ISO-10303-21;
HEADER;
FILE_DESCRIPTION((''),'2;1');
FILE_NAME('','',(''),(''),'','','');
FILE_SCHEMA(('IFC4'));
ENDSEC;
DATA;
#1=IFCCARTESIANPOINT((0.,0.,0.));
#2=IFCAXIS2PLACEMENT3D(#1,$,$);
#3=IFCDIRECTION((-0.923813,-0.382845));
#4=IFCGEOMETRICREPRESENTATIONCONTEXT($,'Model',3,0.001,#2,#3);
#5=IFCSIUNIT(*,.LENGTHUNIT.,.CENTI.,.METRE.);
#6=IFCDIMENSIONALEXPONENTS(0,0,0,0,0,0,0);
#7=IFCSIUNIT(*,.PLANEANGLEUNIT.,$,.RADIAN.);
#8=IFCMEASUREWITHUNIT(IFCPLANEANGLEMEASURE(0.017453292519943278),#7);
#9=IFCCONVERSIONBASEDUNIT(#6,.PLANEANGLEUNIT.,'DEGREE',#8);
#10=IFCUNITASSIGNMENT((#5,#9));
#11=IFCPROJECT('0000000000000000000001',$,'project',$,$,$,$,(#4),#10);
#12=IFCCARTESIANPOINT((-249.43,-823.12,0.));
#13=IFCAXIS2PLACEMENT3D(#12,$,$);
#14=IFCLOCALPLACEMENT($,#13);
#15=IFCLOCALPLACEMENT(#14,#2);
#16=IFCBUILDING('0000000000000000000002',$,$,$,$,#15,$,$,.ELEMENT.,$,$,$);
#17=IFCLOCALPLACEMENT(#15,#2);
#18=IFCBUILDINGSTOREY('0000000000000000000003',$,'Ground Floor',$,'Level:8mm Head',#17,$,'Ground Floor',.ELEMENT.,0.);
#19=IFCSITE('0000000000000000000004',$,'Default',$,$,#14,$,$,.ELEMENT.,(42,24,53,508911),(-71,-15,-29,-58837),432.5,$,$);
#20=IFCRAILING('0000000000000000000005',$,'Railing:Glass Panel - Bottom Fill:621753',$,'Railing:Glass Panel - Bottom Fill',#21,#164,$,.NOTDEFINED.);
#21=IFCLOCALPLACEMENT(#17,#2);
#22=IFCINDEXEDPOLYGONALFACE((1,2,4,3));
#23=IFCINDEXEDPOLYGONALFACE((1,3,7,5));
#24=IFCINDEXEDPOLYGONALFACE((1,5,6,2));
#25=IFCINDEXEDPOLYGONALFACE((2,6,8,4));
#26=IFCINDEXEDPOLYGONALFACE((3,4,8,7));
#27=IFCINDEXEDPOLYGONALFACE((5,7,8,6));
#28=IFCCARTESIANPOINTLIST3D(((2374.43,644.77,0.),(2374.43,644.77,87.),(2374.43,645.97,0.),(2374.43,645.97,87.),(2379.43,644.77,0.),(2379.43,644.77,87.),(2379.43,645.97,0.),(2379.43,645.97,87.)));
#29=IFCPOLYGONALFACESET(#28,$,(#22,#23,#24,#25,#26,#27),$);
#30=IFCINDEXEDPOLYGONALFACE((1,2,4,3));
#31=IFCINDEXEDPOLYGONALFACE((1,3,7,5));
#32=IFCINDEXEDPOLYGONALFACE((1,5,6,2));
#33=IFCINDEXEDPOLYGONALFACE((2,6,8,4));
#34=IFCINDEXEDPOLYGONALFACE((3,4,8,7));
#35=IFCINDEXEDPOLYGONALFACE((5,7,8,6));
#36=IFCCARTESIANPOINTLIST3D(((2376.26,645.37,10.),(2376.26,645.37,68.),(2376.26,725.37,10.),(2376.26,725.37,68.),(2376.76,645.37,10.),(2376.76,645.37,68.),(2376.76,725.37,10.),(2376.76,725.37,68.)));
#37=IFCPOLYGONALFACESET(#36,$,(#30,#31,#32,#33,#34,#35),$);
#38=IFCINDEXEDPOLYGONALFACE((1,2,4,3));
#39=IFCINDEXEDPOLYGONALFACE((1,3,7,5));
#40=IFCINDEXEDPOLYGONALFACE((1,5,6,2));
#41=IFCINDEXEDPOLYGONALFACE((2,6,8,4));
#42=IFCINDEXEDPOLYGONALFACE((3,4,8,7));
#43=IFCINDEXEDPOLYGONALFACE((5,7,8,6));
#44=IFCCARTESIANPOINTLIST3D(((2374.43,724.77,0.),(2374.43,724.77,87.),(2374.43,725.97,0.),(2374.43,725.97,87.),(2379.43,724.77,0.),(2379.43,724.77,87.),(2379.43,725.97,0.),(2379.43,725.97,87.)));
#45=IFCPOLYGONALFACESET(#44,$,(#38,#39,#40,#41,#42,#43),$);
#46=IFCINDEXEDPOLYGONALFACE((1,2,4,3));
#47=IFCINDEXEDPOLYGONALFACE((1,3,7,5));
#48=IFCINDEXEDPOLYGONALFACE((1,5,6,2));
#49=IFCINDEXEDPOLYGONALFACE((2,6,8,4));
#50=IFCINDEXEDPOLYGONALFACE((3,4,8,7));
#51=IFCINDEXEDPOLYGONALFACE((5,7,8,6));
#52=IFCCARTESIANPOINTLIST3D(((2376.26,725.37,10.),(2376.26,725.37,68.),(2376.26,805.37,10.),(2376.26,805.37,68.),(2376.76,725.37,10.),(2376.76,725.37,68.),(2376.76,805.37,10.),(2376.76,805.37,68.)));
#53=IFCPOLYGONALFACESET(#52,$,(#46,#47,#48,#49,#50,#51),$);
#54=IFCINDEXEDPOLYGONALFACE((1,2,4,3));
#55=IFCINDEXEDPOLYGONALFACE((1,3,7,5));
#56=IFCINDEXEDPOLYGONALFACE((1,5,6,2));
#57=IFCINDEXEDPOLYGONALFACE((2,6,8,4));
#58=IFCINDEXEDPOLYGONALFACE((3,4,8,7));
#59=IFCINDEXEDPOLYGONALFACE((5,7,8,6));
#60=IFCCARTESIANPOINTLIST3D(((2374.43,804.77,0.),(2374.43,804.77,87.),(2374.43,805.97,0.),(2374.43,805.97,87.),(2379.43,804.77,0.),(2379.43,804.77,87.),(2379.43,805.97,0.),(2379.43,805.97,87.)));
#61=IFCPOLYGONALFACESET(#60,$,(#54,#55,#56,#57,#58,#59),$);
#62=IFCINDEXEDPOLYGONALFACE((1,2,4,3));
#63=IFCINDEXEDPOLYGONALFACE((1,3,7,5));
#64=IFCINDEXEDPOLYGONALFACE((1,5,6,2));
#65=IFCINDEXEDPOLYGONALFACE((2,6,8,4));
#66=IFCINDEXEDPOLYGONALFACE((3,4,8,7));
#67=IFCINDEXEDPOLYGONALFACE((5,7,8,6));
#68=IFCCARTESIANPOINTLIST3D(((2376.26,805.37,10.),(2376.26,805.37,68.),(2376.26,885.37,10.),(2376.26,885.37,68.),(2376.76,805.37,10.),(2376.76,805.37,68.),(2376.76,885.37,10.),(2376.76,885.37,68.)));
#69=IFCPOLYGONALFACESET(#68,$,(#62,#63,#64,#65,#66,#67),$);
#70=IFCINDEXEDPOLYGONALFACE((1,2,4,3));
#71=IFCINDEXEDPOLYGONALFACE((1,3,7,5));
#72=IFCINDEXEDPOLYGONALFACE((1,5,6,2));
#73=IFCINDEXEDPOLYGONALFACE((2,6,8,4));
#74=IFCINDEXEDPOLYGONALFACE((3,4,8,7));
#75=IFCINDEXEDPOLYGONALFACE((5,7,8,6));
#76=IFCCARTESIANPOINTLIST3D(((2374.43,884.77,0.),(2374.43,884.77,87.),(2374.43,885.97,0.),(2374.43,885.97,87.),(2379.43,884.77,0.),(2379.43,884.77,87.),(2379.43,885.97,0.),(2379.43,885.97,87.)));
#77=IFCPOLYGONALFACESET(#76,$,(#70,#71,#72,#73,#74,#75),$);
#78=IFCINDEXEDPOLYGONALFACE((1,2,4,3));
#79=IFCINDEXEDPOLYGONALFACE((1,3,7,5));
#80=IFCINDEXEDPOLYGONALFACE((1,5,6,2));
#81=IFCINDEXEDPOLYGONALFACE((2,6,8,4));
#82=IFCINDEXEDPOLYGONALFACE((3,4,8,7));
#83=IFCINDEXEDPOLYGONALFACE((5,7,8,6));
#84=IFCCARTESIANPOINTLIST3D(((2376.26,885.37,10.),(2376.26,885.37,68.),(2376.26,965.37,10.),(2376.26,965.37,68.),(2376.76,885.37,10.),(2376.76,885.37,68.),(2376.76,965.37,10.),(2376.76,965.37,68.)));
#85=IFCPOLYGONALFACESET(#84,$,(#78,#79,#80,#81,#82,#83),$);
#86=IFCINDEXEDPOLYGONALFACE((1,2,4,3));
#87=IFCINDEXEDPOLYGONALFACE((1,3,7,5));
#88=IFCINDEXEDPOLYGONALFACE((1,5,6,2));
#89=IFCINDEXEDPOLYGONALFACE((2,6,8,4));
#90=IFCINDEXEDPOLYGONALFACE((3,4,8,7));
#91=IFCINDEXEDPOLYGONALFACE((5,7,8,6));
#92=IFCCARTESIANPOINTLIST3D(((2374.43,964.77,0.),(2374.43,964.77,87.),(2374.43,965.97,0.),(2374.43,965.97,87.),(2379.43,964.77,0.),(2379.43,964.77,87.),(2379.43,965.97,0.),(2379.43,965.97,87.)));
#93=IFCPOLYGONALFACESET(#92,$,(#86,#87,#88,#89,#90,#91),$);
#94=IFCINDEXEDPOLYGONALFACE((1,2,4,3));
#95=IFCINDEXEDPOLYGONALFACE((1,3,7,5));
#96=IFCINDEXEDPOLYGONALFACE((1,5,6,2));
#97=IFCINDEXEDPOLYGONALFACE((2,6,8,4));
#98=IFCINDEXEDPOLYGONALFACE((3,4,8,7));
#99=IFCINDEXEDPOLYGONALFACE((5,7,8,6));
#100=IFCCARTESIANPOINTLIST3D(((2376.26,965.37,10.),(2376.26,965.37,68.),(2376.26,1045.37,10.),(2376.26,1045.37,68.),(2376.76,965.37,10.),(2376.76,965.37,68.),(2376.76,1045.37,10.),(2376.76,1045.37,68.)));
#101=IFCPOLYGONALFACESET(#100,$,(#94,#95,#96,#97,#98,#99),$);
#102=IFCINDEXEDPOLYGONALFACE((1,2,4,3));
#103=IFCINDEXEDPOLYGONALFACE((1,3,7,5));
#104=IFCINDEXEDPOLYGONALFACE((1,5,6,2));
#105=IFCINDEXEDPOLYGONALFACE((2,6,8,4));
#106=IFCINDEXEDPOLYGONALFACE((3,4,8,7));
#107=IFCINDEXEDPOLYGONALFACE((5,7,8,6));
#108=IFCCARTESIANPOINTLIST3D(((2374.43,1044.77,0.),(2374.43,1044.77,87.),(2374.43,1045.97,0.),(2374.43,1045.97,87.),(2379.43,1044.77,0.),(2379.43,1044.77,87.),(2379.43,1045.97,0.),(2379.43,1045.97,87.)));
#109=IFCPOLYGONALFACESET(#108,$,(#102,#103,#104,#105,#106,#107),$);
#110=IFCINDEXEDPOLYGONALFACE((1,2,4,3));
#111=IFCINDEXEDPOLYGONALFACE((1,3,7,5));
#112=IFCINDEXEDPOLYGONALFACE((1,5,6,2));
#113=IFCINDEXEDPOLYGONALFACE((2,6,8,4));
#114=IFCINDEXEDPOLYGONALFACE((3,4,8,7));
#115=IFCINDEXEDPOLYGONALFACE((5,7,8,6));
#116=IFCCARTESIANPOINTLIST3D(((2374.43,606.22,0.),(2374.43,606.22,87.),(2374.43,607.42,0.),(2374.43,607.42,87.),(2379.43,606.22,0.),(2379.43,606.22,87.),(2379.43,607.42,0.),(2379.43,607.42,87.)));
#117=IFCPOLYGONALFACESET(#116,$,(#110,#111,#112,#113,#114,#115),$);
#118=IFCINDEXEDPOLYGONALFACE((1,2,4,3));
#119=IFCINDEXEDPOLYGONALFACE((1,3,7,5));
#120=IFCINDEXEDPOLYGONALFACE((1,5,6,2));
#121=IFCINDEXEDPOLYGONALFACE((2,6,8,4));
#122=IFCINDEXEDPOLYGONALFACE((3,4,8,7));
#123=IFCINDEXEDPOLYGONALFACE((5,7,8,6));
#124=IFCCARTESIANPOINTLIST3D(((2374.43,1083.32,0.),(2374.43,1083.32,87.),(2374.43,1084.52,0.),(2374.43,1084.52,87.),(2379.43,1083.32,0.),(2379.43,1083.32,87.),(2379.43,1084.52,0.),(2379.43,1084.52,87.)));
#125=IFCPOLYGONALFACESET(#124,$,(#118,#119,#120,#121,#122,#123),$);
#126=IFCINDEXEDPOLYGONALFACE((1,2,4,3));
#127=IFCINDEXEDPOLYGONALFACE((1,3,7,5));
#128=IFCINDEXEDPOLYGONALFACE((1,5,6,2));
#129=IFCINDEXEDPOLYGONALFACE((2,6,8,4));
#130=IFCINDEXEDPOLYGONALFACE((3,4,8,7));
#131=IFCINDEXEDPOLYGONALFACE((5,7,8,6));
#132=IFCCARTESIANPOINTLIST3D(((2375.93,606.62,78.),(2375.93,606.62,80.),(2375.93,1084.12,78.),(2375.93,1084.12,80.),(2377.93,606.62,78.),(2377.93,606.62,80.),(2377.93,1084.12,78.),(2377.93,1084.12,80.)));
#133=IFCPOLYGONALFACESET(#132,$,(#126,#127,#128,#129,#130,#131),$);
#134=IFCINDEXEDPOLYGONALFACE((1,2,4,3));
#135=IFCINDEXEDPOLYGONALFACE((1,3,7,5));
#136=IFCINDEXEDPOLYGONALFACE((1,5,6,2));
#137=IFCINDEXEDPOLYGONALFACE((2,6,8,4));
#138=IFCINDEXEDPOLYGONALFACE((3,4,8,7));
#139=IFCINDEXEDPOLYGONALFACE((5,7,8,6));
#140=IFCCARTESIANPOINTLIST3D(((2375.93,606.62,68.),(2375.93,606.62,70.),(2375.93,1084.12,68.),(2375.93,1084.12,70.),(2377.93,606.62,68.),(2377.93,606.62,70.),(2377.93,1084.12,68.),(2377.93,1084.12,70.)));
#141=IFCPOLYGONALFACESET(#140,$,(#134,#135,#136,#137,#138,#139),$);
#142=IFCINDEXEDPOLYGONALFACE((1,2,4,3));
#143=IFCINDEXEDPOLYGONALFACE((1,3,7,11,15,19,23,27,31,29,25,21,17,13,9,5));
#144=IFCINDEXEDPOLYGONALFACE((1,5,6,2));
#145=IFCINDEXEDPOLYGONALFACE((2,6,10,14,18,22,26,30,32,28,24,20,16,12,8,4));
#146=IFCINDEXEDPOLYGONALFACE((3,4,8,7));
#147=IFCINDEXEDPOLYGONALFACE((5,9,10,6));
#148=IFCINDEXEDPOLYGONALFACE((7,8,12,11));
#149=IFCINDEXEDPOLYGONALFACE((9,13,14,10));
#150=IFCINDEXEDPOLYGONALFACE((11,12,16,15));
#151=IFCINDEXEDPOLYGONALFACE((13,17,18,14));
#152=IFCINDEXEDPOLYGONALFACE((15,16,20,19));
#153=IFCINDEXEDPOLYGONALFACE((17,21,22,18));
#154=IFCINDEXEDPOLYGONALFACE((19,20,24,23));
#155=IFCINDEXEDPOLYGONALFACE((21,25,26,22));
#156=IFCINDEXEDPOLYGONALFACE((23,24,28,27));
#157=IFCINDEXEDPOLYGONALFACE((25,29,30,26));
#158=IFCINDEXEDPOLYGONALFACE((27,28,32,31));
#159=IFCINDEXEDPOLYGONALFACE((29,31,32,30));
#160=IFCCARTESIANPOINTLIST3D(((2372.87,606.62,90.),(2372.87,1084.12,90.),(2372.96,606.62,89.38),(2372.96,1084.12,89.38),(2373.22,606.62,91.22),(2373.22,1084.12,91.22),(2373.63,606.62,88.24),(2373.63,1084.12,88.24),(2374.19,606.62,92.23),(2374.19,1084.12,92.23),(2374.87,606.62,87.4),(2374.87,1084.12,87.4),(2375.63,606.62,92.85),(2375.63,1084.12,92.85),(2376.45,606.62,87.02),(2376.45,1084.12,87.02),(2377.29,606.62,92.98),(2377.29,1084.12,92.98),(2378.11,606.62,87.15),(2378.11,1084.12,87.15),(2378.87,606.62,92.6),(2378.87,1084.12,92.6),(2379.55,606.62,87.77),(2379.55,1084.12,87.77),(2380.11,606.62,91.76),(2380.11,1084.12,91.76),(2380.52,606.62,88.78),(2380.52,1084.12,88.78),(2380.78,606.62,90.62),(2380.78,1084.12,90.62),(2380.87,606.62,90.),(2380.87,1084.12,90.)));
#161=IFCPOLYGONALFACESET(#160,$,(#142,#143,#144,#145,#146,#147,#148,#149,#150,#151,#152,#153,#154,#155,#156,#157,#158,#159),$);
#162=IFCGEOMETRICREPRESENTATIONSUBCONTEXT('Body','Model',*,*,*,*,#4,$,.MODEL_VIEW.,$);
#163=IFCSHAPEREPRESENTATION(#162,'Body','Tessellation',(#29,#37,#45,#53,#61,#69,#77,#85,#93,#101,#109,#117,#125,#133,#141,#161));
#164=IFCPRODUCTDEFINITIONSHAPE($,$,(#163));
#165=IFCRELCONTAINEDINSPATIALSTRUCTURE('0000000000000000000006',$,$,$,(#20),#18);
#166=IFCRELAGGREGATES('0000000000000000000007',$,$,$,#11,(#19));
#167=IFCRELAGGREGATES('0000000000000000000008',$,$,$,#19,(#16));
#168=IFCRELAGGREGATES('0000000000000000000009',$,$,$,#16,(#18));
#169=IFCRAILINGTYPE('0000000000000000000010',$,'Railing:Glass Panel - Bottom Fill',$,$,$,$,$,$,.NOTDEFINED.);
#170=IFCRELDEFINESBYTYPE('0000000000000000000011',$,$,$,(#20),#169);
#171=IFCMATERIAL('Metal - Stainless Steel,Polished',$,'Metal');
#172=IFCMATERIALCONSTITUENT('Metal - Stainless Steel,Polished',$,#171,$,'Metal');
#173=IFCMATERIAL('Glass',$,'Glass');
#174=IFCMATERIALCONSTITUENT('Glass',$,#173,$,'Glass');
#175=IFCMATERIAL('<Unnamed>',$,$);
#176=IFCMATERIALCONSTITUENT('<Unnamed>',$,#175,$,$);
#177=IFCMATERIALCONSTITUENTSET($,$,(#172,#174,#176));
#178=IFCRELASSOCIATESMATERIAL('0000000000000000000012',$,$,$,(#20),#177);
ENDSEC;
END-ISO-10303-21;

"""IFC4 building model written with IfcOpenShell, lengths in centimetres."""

from ifc_helpers import new_model, entity, si_unit, converted_unit, direction, frame, origin, place, context, subcontext, project, spatial, indexed_curve, outline, extrude, material, constituent, constituent_set, type_object, element, save


model = new_model("IFC4")

# Units and contexts
model_context = context("Model", 3, precision=0.001, world=origin(), true_north=direction((-0.923813, -0.382845)))
body_context = subcontext(model_context, "Body", "Model", "MODEL_VIEW")
ifc_project = project(units=[si_unit("LENGTHUNIT", "METRE", prefix="CENTI"), converted_unit("PLANEANGLEUNIT", "DEGREE", entity("IfcPlaneAngleMeasure", 0.017453292519943278), si_unit("PLANEANGLEUNIT", "RADIAN"), dimensions=[0, 0, 0, 0, 0, 0, 0])], contexts=[model_context])

# Site, building, storey
site_placement = place(None, frame((-249.43, -823.12, 0.0)))
site = spatial("IfcSite", under=ifc_project, at=site_placement, Name="Default", CompositionType="ELEMENT", RefLatitude=(42, 24, 53, 508911), RefLongitude=(-71, -15, -29, -58837), RefElevation=432.5)
building_placement = place(site_placement, origin())
building = spatial("IfcBuilding", under=site, at=building_placement, CompositionType="ELEMENT")
storey_placement = place(building_placement, origin())
storey = spatial("IfcBuildingStorey", under=building, at=storey_placement, Name="Ground Floor", ObjectType="Level:8mm Head", LongName="Ground Floor", CompositionType="ELEMENT", Elevation=0.0)

# Shared definitions
ifc_material_1 = material(Name="Glass", Category="Glass")

# Railing
ifc_material_2 = material(Name="Metal - Stainless Steel,Polished", Category="Metal")
ifc_material_3 = material(Name="<Unnamed>")
railing_type = type_object("IfcRailingType", Name="Railing:Glass Panel - Bottom Fill", PredefinedType="NOTDEFINED")
ifc_constituent_1 = constituent(ifc_material_2, Name="Metal - Stainless Steel,Polished", Category="Metal")
ifc_constituent_2 = constituent(ifc_material_1, Name="Glass", Category="Glass")
ifc_constituent_3 = constituent(ifc_material_3, Name="<Unnamed>")
ifc_constituent_set_1 = constituent_set(constituents=[ifc_constituent_1, ifc_constituent_2, ifc_constituent_3])
railing_1_placement = place(storey_placement, origin())
element("IfcRailing", 1, at=railing_1_placement, inside=storey, type_object=railing_type, material=ifc_constituent_set_1, Name="Railing:Glass Panel - Bottom Fill:621753", ObjectType="Railing:Glass Panel - Bottom Fill", PredefinedType="NOTDEFINED", context=body_context, shape_type="SweptSolid", body=[
    extrude(outline(indexed_curve([(-2.5, -0.6), (2.5, -0.6), (2.5, 0.6), (-2.5, 0.6), (-2.5, -0.6)], self_intersect=False)), frame((2376.93, 645.37, 0.0), z_axis=(0.0, 0.0, 1.0), x_axis=(-1.0, 0.0, 0.0)), (0.0, 0.0, 1.0), 87.0),
    extrude(outline(indexed_curve([(-0.25, -40.0), (0.25, -40.0), (0.25, 40.0), (-0.25, 40.0), (-0.25, -40.0)], self_intersect=False)), frame((2376.51, 685.37, 10.0), z_axis=(0.0, 0.0, 1.0), x_axis=(-1.0, 0.0, 0.0)), (0.0, 0.0, 1.0), 58.0),
    extrude(outline(indexed_curve([(-2.5, -0.6), (2.5, -0.6), (2.5, 0.6), (-2.5, 0.6), (-2.5, -0.6)], self_intersect=False)), frame((2376.93, 725.37, 0.0), z_axis=(0.0, 0.0, 1.0), x_axis=(-1.0, 0.0, 0.0)), (0.0, 0.0, 1.0), 87.0),
    extrude(outline(indexed_curve([(-0.25, -40.0), (0.25, -40.0), (0.25, 40.0), (-0.25, 40.0), (-0.25, -40.0)], self_intersect=False)), frame((2376.51, 765.37, 10.0), z_axis=(0.0, 0.0, 1.0), x_axis=(-1.0, 0.0, 0.0)), (0.0, 0.0, 1.0), 58.0),
    extrude(outline(indexed_curve([(-2.5, -0.6), (2.5, -0.6), (2.5, 0.6), (-2.5, 0.6), (-2.5, -0.6)], self_intersect=False)), frame((2376.93, 805.37, 0.0), z_axis=(0.0, 0.0, 1.0), x_axis=(-1.0, 0.0, 0.0)), (0.0, 0.0, 1.0), 87.0),
    extrude(outline(indexed_curve([(-0.25, -40.0), (0.25, -40.0), (0.25, 40.0), (-0.25, 40.0), (-0.25, -40.0)], self_intersect=False)), frame((2376.51, 845.37, 10.0), z_axis=(0.0, 0.0, 1.0), x_axis=(-1.0, 0.0, 0.0)), (0.0, 0.0, 1.0), 58.0),
    extrude(outline(indexed_curve([(-2.5, -0.6), (2.5, -0.6), (2.5, 0.6), (-2.5, 0.6), (-2.5, -0.6)], self_intersect=False)), frame((2376.93, 885.37, 0.0), z_axis=(0.0, 0.0, 1.0), x_axis=(-1.0, 0.0, 0.0)), (0.0, 0.0, 1.0), 87.0),
    extrude(outline(indexed_curve([(-0.25, -40.0), (0.25, -40.0), (0.25, 40.0), (-0.25, 40.0), (-0.25, -40.0)], self_intersect=False)), frame((2376.51, 925.37, 10.0), z_axis=(0.0, 0.0, 1.0), x_axis=(-1.0, 0.0, 0.0)), (0.0, 0.0, 1.0), 58.0),
    extrude(outline(indexed_curve([(-2.5, -0.6), (2.5, -0.6), (2.5, 0.6), (-2.5, 0.6), (-2.5, -0.6)], self_intersect=False)), frame((2376.93, 965.37, 0.0), z_axis=(0.0, 0.0, 1.0), x_axis=(-1.0, 0.0, 0.0)), (0.0, 0.0, 1.0), 87.0),
    extrude(outline(indexed_curve([(-0.25, -40.0), (0.25, -40.0), (0.25, 40.0), (-0.25, 40.0), (-0.25, -40.0)], self_intersect=False)), frame((2376.51, 1005.37, 10.0), z_axis=(0.0, 0.0, 1.0), x_axis=(-1.0, 0.0, 0.0)), (0.0, 0.0, 1.0), 58.0),
    extrude(outline(indexed_curve([(-2.5, -0.6), (2.5, -0.6), (2.5, 0.6), (-2.5, 0.6), (-2.5, -0.6)], self_intersect=False)), frame((2376.93, 1045.37, 0.0), z_axis=(0.0, 0.0, 1.0), x_axis=(-1.0, 0.0, 0.0)), (0.0, 0.0, 1.0), 87.0),
    extrude(outline(indexed_curve([(-2.5, -0.6), (2.5, -0.6), (2.5, 0.6), (-2.5, 0.6), (-2.5, -0.6)], self_intersect=False)), frame((2376.93, 606.82, 0.0), z_axis=(0.0, 0.0, 1.0), x_axis=(-1.0, 0.0, 0.0)), (0.0, 0.0, 1.0), 87.0),
    extrude(outline(indexed_curve([(-2.5, -0.6), (2.5, -0.6), (2.5, 0.6), (-2.5, 0.6), (-2.5, -0.6)], self_intersect=False)), frame((2376.93, 1083.92, 0.0), z_axis=(0.0, 0.0, 1.0), x_axis=(-1.0, 0.0, 0.0)), (0.0, 0.0, 1.0), 87.0),
    extrude(outline(indexed_curve([(-238.75, -1.0), (238.75, -1.0), (238.75, 1.0), (-238.75, 1.0), (-238.75, -1.0)], self_intersect=False)), frame((2376.93, 845.37, 78.0), z_axis=(0.0, 0.0, 1.0), x_axis=(0.0, -1.0, 0.0)), (0.0, 0.0, 1.0), 2.0),
    extrude(outline(indexed_curve([(-238.75, -1.0), (238.75, -1.0), (238.75, 1.0), (-238.75, 1.0), (-238.75, -1.0)], self_intersect=False)), frame((2376.93, 845.37, 68.0), z_axis=(0.0, 0.0, 1.0), x_axis=(0.0, -1.0, 0.0)), (0.0, 0.0, 1.0), 2.0),
    extrude(outline(indexed_curve([(-1.09, -3.85), (0.18, -3.85), (1.42, -3.18), (2.41, -1.97), (2.98, -0.41), (3.04, 1.22), (2.58, 2.63), (1.67, 3.59), (1.09, 3.85), (-0.18, 3.85), (-1.42, 3.18), (-2.41, 1.97), (-2.98, 0.41), (-3.04, -1.22), (-2.58, -2.63), (-1.67, -3.59), (-1.09, -3.85)], self_intersect=False)), frame((2376.87, 606.62, 90.0), z_axis=(0.0, 1.0, 0.0), x_axis=(-0.27267, 0.0, -0.962108)), (0.0, 0.0, 1.0), 477.5),
])

save(model, "model.ifc")
